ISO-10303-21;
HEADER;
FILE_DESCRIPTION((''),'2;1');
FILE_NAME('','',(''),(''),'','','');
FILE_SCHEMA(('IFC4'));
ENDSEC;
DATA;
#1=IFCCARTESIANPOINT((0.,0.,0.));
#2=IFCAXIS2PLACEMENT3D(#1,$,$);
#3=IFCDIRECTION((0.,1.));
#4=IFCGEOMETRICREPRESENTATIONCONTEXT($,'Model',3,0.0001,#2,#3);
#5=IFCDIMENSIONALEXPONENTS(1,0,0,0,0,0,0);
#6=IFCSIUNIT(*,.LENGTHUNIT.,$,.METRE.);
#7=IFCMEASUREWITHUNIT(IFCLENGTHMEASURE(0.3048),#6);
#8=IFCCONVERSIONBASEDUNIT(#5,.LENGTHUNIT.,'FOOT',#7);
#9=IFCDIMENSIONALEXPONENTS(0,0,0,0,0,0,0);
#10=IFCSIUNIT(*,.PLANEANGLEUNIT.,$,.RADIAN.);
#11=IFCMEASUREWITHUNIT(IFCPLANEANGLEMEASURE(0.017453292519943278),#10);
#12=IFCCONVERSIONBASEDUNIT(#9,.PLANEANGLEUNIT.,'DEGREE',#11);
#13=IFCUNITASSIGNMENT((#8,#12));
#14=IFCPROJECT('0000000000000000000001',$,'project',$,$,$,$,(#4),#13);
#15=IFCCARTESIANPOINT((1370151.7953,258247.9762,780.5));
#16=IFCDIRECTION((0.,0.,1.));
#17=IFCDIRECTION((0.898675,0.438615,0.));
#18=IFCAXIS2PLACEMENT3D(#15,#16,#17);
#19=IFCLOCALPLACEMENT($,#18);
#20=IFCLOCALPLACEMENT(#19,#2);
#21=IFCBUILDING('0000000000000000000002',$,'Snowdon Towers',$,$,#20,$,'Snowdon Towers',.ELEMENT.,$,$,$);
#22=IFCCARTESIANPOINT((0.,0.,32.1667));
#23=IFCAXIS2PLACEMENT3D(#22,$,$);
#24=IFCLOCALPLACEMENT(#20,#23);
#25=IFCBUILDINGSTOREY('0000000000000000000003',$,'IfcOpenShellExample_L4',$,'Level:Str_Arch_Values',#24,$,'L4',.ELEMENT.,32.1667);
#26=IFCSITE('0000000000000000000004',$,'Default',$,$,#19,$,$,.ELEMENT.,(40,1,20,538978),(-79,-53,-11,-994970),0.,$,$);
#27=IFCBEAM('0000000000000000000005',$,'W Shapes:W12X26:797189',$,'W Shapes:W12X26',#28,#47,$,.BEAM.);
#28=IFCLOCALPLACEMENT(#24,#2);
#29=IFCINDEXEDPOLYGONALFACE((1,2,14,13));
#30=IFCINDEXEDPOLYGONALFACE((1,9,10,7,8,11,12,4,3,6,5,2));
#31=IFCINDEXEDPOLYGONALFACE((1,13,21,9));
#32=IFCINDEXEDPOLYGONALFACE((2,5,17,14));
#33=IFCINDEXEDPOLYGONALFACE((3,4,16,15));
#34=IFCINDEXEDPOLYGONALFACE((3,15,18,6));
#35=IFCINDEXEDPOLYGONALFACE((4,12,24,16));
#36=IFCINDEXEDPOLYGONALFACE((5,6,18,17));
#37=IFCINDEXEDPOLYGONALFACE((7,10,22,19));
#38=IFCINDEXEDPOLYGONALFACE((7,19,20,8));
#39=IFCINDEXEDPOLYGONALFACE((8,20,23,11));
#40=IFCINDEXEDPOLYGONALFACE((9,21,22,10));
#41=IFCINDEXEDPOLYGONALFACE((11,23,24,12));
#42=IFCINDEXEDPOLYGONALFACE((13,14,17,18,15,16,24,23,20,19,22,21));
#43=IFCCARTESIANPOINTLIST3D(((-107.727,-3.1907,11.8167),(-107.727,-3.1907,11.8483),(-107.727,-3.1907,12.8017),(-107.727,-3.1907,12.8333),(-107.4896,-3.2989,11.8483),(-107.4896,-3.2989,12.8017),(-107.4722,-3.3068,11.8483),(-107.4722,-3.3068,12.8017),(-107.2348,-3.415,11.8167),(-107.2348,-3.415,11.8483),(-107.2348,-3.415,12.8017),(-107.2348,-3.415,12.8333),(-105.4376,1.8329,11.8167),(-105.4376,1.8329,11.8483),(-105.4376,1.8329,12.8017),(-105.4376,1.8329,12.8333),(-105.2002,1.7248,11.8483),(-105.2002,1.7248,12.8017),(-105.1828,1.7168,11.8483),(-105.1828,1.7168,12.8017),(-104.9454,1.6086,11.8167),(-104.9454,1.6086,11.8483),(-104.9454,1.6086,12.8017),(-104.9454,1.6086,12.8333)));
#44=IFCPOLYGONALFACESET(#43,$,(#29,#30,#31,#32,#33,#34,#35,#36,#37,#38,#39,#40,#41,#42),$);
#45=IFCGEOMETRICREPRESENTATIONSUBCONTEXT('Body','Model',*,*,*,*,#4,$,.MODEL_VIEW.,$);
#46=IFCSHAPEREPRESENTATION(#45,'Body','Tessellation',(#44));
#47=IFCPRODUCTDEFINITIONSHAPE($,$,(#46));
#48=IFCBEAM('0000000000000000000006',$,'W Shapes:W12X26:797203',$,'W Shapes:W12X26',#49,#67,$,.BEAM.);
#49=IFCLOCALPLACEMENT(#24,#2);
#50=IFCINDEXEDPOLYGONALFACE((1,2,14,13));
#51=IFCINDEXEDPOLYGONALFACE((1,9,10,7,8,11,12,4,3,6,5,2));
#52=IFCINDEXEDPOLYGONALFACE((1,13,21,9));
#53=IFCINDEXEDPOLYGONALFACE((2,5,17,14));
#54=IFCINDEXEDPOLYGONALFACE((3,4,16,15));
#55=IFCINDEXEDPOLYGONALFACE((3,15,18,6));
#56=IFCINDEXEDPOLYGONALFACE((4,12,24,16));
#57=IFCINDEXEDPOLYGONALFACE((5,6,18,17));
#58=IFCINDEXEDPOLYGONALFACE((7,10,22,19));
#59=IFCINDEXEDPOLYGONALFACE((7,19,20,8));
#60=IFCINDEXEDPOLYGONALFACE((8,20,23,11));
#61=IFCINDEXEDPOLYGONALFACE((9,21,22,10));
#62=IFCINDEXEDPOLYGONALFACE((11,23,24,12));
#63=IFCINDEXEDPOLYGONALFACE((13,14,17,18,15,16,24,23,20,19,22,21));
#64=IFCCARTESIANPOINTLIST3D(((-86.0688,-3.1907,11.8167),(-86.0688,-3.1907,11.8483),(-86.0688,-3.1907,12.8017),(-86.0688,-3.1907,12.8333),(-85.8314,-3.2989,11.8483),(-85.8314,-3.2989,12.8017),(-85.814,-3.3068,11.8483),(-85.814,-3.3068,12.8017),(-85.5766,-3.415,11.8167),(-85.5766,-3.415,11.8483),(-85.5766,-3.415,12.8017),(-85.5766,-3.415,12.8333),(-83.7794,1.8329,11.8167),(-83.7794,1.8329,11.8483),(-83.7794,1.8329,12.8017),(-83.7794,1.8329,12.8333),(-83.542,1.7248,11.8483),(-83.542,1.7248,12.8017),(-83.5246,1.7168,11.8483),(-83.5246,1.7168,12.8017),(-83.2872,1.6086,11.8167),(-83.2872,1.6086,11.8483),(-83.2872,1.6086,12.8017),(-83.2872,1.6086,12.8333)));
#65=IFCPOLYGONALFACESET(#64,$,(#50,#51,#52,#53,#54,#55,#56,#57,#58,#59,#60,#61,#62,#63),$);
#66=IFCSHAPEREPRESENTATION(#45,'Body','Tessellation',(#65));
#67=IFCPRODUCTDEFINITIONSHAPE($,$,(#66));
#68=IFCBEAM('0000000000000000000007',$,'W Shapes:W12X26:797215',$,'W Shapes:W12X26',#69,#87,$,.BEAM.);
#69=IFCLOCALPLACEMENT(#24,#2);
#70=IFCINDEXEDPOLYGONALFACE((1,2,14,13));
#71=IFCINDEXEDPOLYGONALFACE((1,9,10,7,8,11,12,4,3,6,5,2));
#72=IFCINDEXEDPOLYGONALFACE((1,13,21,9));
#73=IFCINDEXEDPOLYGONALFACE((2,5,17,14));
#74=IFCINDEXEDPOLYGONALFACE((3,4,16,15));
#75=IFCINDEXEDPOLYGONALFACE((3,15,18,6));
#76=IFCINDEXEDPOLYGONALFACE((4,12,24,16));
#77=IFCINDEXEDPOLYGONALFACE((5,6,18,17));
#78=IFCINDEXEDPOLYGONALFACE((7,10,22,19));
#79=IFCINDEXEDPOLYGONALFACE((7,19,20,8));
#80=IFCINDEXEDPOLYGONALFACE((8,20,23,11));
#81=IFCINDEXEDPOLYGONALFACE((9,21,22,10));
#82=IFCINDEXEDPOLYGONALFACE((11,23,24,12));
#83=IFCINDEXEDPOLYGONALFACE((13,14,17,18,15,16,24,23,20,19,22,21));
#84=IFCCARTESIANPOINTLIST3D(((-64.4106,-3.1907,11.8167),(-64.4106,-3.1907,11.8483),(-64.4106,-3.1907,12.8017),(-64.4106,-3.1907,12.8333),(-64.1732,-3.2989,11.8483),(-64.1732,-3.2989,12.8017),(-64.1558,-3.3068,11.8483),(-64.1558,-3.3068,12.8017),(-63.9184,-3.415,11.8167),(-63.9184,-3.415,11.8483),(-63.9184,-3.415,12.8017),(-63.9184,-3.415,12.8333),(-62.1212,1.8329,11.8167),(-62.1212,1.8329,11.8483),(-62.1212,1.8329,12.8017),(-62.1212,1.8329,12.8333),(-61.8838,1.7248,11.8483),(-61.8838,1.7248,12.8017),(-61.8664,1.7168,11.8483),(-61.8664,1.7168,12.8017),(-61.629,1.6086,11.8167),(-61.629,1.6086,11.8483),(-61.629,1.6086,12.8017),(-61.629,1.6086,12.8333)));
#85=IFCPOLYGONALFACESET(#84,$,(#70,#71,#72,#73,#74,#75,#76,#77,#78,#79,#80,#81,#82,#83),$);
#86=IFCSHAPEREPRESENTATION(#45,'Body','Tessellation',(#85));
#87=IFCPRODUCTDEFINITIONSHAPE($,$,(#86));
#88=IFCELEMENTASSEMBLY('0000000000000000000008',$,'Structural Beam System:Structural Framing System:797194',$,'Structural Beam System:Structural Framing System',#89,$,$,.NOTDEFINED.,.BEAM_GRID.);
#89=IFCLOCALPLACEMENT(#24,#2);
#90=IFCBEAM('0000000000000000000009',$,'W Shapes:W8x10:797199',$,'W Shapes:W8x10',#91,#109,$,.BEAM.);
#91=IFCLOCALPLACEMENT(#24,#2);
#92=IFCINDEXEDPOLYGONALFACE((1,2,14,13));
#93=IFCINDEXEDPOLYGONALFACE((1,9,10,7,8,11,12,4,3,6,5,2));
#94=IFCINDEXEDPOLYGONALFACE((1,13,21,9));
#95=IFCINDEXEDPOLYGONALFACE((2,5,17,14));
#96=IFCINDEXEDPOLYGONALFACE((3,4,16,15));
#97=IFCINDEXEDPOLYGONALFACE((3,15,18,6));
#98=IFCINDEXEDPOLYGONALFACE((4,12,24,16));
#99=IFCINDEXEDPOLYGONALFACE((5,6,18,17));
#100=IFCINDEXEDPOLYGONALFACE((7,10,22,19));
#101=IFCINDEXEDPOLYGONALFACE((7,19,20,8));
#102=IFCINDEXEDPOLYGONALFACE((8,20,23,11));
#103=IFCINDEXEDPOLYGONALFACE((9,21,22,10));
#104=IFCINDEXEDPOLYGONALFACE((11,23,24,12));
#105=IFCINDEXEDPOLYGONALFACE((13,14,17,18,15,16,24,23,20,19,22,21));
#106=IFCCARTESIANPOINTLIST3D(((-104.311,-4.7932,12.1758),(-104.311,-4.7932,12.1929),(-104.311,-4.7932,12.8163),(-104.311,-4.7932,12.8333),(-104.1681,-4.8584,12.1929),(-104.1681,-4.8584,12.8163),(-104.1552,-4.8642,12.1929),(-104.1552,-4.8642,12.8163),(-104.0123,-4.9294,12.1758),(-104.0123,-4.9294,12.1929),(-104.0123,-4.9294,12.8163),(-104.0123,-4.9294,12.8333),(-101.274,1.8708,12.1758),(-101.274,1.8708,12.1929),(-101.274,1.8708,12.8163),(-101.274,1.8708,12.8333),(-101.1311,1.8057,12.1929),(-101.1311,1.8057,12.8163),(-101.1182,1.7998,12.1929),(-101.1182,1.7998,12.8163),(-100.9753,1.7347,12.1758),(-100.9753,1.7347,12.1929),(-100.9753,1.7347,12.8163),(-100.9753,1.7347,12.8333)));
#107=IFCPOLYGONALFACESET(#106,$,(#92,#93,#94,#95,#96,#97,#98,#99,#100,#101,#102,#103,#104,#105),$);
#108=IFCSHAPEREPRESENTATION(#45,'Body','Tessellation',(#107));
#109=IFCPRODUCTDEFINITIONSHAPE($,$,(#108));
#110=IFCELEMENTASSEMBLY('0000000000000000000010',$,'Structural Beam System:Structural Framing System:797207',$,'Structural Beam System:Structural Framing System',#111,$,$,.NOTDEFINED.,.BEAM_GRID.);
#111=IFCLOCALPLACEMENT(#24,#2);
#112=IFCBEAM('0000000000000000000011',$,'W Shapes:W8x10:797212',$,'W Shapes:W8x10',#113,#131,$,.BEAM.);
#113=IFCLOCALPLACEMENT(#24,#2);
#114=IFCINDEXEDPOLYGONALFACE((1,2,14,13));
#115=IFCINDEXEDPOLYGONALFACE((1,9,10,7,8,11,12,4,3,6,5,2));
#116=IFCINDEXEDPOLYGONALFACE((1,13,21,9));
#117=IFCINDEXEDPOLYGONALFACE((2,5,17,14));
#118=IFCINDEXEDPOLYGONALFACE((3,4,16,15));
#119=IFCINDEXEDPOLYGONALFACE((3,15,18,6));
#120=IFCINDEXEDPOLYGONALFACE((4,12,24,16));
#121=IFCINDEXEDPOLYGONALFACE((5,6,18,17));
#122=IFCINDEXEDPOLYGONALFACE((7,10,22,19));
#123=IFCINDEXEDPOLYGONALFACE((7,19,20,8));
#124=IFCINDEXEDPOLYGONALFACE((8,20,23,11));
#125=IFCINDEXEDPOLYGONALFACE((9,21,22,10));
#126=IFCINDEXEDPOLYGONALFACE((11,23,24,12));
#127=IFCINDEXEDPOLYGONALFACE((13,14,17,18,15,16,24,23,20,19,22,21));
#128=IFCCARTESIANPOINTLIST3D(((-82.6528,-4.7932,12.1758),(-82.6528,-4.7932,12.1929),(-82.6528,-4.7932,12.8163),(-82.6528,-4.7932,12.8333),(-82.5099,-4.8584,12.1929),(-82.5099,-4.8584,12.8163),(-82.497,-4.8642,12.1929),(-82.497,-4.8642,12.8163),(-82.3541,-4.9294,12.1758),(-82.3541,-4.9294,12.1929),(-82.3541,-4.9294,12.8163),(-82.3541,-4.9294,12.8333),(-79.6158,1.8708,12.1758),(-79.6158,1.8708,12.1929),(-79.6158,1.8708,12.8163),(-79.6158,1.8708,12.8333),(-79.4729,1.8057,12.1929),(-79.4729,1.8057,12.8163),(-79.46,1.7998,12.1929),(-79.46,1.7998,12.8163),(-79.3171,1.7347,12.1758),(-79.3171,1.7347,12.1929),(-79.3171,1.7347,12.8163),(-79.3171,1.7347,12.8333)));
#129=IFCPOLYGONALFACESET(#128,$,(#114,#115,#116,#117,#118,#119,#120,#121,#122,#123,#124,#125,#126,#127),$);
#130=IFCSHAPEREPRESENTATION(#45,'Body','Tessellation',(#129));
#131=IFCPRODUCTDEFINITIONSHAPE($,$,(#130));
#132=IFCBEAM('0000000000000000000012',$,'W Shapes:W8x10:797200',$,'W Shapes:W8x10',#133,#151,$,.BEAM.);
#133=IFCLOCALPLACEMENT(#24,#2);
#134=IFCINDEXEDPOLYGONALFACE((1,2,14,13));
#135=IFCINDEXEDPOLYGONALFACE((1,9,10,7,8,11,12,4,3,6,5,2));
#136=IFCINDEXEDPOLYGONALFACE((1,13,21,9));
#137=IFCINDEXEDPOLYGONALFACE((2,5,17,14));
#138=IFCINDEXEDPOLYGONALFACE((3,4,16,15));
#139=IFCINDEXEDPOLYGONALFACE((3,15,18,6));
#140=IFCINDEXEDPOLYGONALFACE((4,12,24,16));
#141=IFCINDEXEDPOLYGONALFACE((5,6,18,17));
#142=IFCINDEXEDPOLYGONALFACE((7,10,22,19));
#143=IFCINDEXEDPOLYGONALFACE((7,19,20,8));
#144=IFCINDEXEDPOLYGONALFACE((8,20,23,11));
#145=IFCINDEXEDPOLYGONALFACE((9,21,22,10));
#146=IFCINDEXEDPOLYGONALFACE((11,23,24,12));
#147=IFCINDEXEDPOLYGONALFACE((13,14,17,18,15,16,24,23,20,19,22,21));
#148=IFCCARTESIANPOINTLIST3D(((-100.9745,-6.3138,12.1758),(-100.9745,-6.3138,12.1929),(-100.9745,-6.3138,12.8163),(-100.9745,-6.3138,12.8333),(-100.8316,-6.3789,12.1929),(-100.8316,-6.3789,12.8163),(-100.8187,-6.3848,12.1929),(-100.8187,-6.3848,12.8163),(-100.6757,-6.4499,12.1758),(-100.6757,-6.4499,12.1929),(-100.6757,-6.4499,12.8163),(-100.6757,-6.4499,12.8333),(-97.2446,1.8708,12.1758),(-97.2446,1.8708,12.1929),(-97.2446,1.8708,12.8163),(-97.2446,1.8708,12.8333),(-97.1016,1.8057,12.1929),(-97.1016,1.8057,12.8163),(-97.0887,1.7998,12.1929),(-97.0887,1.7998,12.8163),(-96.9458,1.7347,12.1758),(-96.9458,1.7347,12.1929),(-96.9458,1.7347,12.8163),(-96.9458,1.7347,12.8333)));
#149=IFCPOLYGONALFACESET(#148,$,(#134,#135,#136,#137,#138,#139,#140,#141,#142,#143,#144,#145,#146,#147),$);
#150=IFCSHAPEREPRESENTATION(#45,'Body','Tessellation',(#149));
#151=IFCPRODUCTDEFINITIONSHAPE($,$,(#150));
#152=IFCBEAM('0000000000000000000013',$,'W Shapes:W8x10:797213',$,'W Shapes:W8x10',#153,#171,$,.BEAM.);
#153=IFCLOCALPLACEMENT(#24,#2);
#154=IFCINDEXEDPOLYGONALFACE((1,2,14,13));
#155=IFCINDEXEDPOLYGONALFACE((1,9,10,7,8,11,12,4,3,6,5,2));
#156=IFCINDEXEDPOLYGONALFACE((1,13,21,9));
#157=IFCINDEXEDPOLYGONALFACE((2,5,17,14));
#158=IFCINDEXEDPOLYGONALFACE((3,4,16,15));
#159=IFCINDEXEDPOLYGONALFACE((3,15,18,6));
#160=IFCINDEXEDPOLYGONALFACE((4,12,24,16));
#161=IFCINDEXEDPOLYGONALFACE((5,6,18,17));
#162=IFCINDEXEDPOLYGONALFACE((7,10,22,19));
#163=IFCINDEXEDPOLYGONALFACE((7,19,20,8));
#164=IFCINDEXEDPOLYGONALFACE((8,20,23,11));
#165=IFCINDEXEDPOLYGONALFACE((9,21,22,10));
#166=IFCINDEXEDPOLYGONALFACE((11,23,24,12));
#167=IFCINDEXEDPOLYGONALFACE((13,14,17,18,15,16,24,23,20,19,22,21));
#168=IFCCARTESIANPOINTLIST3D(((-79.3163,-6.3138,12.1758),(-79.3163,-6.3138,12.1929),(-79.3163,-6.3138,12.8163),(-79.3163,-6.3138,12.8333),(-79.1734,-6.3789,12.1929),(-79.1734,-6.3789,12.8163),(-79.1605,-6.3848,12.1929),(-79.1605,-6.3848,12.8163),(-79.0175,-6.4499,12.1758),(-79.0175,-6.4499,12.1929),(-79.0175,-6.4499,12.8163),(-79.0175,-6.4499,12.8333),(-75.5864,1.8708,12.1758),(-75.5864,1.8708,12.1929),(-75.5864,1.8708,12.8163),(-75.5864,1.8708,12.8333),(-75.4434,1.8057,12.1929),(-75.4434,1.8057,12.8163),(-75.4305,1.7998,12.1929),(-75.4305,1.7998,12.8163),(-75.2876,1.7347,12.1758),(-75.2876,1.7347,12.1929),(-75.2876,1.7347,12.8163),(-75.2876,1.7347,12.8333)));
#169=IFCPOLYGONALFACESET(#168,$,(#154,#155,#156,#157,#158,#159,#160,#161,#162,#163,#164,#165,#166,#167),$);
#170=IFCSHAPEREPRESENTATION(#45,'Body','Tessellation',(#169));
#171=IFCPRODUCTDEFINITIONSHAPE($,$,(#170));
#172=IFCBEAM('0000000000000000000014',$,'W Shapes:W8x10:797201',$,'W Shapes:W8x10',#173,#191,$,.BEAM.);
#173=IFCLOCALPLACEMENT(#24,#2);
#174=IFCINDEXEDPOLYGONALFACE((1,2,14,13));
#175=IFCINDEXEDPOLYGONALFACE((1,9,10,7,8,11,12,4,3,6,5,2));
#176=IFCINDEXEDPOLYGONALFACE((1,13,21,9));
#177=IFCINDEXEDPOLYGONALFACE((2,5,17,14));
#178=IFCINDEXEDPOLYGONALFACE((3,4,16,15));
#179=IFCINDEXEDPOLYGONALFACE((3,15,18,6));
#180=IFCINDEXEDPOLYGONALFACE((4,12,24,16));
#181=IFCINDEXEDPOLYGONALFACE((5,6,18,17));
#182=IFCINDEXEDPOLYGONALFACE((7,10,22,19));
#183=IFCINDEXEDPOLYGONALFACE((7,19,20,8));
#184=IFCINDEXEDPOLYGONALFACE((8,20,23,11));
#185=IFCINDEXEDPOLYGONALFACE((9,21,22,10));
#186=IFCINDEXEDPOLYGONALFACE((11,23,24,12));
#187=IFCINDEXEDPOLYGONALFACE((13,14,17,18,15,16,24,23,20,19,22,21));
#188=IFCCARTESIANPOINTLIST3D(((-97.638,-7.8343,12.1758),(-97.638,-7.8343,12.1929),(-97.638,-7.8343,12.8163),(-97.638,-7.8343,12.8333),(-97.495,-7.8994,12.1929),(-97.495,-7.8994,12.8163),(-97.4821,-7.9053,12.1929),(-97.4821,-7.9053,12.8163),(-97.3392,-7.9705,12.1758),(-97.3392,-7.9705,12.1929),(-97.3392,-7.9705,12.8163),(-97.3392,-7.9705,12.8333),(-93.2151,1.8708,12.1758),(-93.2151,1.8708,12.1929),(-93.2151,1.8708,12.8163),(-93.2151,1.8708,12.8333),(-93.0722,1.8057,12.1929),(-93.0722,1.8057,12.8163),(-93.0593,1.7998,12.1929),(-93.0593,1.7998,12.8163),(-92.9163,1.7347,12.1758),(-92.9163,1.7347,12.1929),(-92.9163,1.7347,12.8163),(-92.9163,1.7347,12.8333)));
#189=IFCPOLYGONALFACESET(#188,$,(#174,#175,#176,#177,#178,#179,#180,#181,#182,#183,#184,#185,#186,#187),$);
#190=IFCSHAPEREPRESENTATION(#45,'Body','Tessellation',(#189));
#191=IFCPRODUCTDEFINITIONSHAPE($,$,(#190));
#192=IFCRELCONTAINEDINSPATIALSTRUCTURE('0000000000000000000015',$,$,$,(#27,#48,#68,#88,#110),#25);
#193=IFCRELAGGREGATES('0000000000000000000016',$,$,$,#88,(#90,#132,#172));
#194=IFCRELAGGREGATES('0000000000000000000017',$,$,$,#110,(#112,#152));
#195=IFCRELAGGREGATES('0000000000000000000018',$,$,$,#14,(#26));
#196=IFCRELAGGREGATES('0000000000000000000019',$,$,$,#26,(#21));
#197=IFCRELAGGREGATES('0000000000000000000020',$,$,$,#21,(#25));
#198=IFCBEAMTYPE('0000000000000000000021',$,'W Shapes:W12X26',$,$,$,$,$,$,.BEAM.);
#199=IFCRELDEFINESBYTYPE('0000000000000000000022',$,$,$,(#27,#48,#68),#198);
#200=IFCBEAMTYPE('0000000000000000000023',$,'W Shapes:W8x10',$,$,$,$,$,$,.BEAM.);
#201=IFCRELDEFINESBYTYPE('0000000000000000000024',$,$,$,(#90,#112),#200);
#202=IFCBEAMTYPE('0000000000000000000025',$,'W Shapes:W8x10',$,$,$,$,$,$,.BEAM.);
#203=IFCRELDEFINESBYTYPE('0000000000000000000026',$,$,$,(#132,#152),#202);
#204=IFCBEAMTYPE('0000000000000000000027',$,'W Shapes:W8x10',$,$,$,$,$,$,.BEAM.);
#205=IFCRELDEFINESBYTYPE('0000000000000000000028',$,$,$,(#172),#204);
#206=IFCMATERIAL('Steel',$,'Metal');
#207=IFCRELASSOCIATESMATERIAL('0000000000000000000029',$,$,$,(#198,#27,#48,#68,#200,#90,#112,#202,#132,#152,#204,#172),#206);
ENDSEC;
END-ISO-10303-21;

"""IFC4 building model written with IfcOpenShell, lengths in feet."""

from ifc_helpers import new_model, entity, si_unit, converted_unit, direction, frame, origin, place, context, subcontext, project, spatial, indexed_curve, outline, extrude, source, transform, mapped, material, type_object, type_shapes, element, aggregate, save


model = new_model("IFC4")

# Units and contexts
model_context = context("Model", 3, precision=0.0001, world=origin(), true_north=direction((0.0, 1.0)))
body_context = subcontext(model_context, "Body", "Model", "MODEL_VIEW")
ifc_project = project(units=[converted_unit("LENGTHUNIT", "FOOT", entity("IfcLengthMeasure", 0.3048), si_unit("LENGTHUNIT", "METRE"), dimensions=[1, 0, 0, 0, 0, 0, 0]), converted_unit("PLANEANGLEUNIT", "DEGREE", entity("IfcPlaneAngleMeasure", 0.017453292519943278), si_unit("PLANEANGLEUNIT", "RADIAN"), dimensions=[0, 0, 0, 0, 0, 0, 0])], contexts=[model_context])

# Site, building, storey
site_placement = place(None, frame((1370151.7953, 258247.9762, 780.5), z_axis=(0.0, 0.0, 1.0), x_axis=(0.898675, 0.438615, 0.0)))
site = spatial("IfcSite", under=ifc_project, at=site_placement, Name="Default", CompositionType="ELEMENT", RefLatitude=(40, 1, 20, 538978), RefLongitude=(-79, -53, -11, -994970), RefElevation=0.0)
building_placement = place(site_placement, origin())
building = spatial("IfcBuilding", under=site, at=building_placement, Name="Snowdon Towers", LongName="Snowdon Towers", CompositionType="ELEMENT")
storey_placement = place(building_placement, frame((0.0, 0.0, 32.1667)))
storey = spatial("IfcBuildingStorey", under=building, at=storey_placement, Name="IfcOpenShellExample_L4", ObjectType="Level:Str_Arch_Values", LongName="L4", CompositionType="ELEMENT", Elevation=32.1667)

# Shared definitions
ifc_material = material(Name="Steel", Category="Metal")

# Beams
beam_type_1 = type_object("IfcBeamType", Name="W Shapes:W12X26", PredefinedType="BEAM", material=ifc_material)
shared_shape_1 = source(origin(), body_context, "Body", "SweptSolid", [
    extrude(outline(indexed_curve([(-0.2704, -0.4767), (-0.2704, -0.5083), (0.2704, -0.5083), (0.2704, -0.4767), (0.0096, -0.4767), (0.0096, 0.4767), (0.2704, 0.4767), (0.2704, 0.5083), (-0.2704, 0.5083), (-0.2704, 0.4767), (-0.0096, 0.4767), (-0.0096, -0.4767), (-0.2704, -0.4767)], self_intersect=False)), frame((-3.0325, 0.0, 0.0), z_axis=(-1.0, 0.0, 0.0), x_axis=(0.0, -1.0, 0.0)), (0.0, 0.0, -1.0), 5.5207),
])
type_shapes(beam_type_1, [shared_shape_1])
for number, where, z_axis, x_axis, name in (
    (1, (-106.2233, -0.5434, 12.325), (0.0, 0.0, 1.0), (0.414693, 0.909961, 0.0), "W Shapes:W12X26:797189"),
    (2, (-84.5651, -0.5434, 12.325), (0.0, 0.0, 1.0), (0.414693, 0.909961, 0.0), "W Shapes:W12X26:797203"),
    (3, (-62.9069, -0.5434, 12.325), (0.0, 0.0, 1.0), (0.414693, 0.909961, 0.0), "W Shapes:W12X26:797215"),
):
    element("IfcBeam", number, at=place(storey_placement, frame(where, z_axis=z_axis, x_axis=x_axis)), inside=storey, type_object=beam_type_1, material=ifc_material, Name=name, ObjectType="W Shapes:W12X26", PredefinedType="BEAM", context=body_context, shape_type="MappedRepresentation", body=[
        mapped(shared_shape_1, transform((0.0, 0.0, 0.0), scale=1.0)),
    ])

# Element assemblies, beams
assembly_1_placement = place(storey_placement, origin())
assembly_1 = element("IfcElementAssembly", 4, at=assembly_1_placement, inside=storey, Name="Structural Beam System:Structural Framing System:797194", ObjectType="Structural Beam System:Structural Framing System", AssemblyPlace="NOTDEFINED", PredefinedType="BEAM_GRID")
beam_type_2 = type_object("IfcBeamType", Name="W Shapes:W8x10", PredefinedType="BEAM", material=ifc_material)
shared_shape_2 = source(origin(), body_context, "Body", "SweptSolid", [
    extrude(outline(indexed_curve([(-0.1642, -0.3117), (-0.1642, -0.3288), (0.1642, -0.3288), (0.1642, -0.3117), (0.0071, -0.3117), (0.0071, 0.3117), (0.1642, 0.3117), (0.1642, 0.3287), (-0.1642, 0.3287), (-0.1642, 0.3117), (-0.0071, 0.3117), (-0.0071, -0.3117), (-0.1642, -0.3117)], self_intersect=False)), frame((-3.9096, 0.0, 0.0), z_axis=(-1.0, 0.0, 0.0), x_axis=(0.0, -1.0, 0.0)), (0.0, 0.0, -1.0), 7.3235),
])
type_shapes(beam_type_2, [shared_shape_2])
beam_1_placement = place(assembly_1_placement, frame((-102.5403, -1.3037, 12.5046), z_axis=(0.0, 0.0, 1.0), x_axis=(0.414693, 0.909961, 0.0)))
beam_1 = element("IfcBeam", 5, at=beam_1_placement, type_object=beam_type_2, material=ifc_material, Name="W Shapes:W8x10:797199", ObjectType="W Shapes:W8x10", PredefinedType="BEAM", context=body_context, shape_type="MappedRepresentation", body=[
    mapped(shared_shape_2, transform((0.0, 0.0, 0.0), scale=1.0)),
])
assembly_2_placement = place(storey_placement, origin())
assembly_2 = element("IfcElementAssembly", 6, at=assembly_2_placement, inside=storey, Name="Structural Beam System:Structural Framing System:797207", ObjectType="Structural Beam System:Structural Framing System", AssemblyPlace="NOTDEFINED", PredefinedType="BEAM_GRID")
beam_2_placement = place(assembly_2_placement, frame((-80.8821, -1.3037, 12.5046), z_axis=(0.0, 0.0, 1.0), x_axis=(0.414693, 0.909961, 0.0)))
beam_2 = element("IfcBeam", 7, at=beam_2_placement, type_object=beam_type_2, material=ifc_material, Name="W Shapes:W8x10:797212", ObjectType="W Shapes:W8x10", PredefinedType="BEAM", context=body_context, shape_type="MappedRepresentation", body=[
    mapped(shared_shape_2, transform((0.0, 0.0, 0.0), scale=1.0)),
])

# Beams
beam_type_3 = type_object("IfcBeamType", Name="W Shapes:W8x10", PredefinedType="BEAM", material=ifc_material)
shared_shape_3 = source(origin(), body_context, "Body", "SweptSolid", [
    extrude(outline(indexed_curve([(-0.1642, -0.3117), (-0.1642, -0.3288), (0.1642, -0.3288), (0.1642, -0.3117), (0.0071, -0.3117), (0.0071, 0.3117), (0.1642, 0.3117), (0.1642, 0.3287), (-0.1642, 0.3287), (-0.1642, 0.3117), (-0.0071, 0.3117), (-0.0071, -0.3117), (-0.1642, -0.3117)], self_intersect=False)), frame((-4.7451, 0.0, 0.0), z_axis=(-1.0, 0.0, 0.0), x_axis=(0.0, -1.0, 0.0)), (0.0, 0.0, -1.0), 8.9944),
])
type_shapes(beam_type_3, [shared_shape_3])
beam_3_placement = place(assembly_1_placement, frame((-98.8573, -2.064, 12.5046), z_axis=(0.0, 0.0, 1.0), x_axis=(0.414693, 0.909961, 0.0)))
beam_3 = element("IfcBeam", 8, at=beam_3_placement, type_object=beam_type_3, material=ifc_material, Name="W Shapes:W8x10:797200", ObjectType="W Shapes:W8x10", PredefinedType="BEAM", context=body_context, shape_type="MappedRepresentation", body=[
    mapped(shared_shape_3, transform((0.0, 0.0, 0.0), scale=1.0)),
])
beam_4_placement = place(assembly_2_placement, frame((-77.1991, -2.064, 12.5046), z_axis=(0.0, 0.0, 1.0), x_axis=(0.414693, 0.909961, 0.0)))
beam_4 = element("IfcBeam", 9, at=beam_4_placement, type_object=beam_type_3, material=ifc_material, Name="W Shapes:W8x10:797213", ObjectType="W Shapes:W8x10", PredefinedType="BEAM", context=body_context, shape_type="MappedRepresentation", body=[
    mapped(shared_shape_3, transform((0.0, 0.0, 0.0), scale=1.0)),
])
beam_type_4 = type_object("IfcBeamType", Name="W Shapes:W8x10", PredefinedType="BEAM", material=ifc_material)
shared_shape_4 = source(origin(), body_context, "Body", "SweptSolid", [
    extrude(outline(indexed_curve([(-0.1642, -0.3117), (-0.1642, -0.3288), (0.1642, -0.3288), (0.1642, -0.3117), (0.0071, -0.3117), (0.0071, 0.3117), (0.1642, 0.3117), (0.1642, 0.3287), (-0.1642, 0.3287), (-0.1642, 0.3117), (-0.0071, 0.3117), (-0.0071, -0.3117), (-0.1642, -0.3117)], self_intersect=False)), frame((-5.5806, 0.0, 0.0), z_axis=(-1.0, 0.0, 0.0), x_axis=(0.0, -1.0, 0.0)), (0.0, 0.0, -1.0), 10.6654),
])
type_shapes(beam_type_4, [shared_shape_4])
beam_5_placement = place(assembly_1_placement, frame((-95.1743, -2.8242, 12.5046), z_axis=(0.0, 0.0, 1.0), x_axis=(0.414693, 0.909961, 0.0)))
beam_5 = element("IfcBeam", 10, at=beam_5_placement, type_object=beam_type_4, material=ifc_material, Name="W Shapes:W8x10:797201", ObjectType="W Shapes:W8x10", PredefinedType="BEAM", context=body_context, shape_type="MappedRepresentation", body=[
    mapped(shared_shape_4, transform((0.0, 0.0, 0.0), scale=1.0)),
])
aggregate(assembly_1, [beam_1, beam_3, beam_5])
aggregate(assembly_2, [beam_2, beam_4])

save(model, "model.ifc")
